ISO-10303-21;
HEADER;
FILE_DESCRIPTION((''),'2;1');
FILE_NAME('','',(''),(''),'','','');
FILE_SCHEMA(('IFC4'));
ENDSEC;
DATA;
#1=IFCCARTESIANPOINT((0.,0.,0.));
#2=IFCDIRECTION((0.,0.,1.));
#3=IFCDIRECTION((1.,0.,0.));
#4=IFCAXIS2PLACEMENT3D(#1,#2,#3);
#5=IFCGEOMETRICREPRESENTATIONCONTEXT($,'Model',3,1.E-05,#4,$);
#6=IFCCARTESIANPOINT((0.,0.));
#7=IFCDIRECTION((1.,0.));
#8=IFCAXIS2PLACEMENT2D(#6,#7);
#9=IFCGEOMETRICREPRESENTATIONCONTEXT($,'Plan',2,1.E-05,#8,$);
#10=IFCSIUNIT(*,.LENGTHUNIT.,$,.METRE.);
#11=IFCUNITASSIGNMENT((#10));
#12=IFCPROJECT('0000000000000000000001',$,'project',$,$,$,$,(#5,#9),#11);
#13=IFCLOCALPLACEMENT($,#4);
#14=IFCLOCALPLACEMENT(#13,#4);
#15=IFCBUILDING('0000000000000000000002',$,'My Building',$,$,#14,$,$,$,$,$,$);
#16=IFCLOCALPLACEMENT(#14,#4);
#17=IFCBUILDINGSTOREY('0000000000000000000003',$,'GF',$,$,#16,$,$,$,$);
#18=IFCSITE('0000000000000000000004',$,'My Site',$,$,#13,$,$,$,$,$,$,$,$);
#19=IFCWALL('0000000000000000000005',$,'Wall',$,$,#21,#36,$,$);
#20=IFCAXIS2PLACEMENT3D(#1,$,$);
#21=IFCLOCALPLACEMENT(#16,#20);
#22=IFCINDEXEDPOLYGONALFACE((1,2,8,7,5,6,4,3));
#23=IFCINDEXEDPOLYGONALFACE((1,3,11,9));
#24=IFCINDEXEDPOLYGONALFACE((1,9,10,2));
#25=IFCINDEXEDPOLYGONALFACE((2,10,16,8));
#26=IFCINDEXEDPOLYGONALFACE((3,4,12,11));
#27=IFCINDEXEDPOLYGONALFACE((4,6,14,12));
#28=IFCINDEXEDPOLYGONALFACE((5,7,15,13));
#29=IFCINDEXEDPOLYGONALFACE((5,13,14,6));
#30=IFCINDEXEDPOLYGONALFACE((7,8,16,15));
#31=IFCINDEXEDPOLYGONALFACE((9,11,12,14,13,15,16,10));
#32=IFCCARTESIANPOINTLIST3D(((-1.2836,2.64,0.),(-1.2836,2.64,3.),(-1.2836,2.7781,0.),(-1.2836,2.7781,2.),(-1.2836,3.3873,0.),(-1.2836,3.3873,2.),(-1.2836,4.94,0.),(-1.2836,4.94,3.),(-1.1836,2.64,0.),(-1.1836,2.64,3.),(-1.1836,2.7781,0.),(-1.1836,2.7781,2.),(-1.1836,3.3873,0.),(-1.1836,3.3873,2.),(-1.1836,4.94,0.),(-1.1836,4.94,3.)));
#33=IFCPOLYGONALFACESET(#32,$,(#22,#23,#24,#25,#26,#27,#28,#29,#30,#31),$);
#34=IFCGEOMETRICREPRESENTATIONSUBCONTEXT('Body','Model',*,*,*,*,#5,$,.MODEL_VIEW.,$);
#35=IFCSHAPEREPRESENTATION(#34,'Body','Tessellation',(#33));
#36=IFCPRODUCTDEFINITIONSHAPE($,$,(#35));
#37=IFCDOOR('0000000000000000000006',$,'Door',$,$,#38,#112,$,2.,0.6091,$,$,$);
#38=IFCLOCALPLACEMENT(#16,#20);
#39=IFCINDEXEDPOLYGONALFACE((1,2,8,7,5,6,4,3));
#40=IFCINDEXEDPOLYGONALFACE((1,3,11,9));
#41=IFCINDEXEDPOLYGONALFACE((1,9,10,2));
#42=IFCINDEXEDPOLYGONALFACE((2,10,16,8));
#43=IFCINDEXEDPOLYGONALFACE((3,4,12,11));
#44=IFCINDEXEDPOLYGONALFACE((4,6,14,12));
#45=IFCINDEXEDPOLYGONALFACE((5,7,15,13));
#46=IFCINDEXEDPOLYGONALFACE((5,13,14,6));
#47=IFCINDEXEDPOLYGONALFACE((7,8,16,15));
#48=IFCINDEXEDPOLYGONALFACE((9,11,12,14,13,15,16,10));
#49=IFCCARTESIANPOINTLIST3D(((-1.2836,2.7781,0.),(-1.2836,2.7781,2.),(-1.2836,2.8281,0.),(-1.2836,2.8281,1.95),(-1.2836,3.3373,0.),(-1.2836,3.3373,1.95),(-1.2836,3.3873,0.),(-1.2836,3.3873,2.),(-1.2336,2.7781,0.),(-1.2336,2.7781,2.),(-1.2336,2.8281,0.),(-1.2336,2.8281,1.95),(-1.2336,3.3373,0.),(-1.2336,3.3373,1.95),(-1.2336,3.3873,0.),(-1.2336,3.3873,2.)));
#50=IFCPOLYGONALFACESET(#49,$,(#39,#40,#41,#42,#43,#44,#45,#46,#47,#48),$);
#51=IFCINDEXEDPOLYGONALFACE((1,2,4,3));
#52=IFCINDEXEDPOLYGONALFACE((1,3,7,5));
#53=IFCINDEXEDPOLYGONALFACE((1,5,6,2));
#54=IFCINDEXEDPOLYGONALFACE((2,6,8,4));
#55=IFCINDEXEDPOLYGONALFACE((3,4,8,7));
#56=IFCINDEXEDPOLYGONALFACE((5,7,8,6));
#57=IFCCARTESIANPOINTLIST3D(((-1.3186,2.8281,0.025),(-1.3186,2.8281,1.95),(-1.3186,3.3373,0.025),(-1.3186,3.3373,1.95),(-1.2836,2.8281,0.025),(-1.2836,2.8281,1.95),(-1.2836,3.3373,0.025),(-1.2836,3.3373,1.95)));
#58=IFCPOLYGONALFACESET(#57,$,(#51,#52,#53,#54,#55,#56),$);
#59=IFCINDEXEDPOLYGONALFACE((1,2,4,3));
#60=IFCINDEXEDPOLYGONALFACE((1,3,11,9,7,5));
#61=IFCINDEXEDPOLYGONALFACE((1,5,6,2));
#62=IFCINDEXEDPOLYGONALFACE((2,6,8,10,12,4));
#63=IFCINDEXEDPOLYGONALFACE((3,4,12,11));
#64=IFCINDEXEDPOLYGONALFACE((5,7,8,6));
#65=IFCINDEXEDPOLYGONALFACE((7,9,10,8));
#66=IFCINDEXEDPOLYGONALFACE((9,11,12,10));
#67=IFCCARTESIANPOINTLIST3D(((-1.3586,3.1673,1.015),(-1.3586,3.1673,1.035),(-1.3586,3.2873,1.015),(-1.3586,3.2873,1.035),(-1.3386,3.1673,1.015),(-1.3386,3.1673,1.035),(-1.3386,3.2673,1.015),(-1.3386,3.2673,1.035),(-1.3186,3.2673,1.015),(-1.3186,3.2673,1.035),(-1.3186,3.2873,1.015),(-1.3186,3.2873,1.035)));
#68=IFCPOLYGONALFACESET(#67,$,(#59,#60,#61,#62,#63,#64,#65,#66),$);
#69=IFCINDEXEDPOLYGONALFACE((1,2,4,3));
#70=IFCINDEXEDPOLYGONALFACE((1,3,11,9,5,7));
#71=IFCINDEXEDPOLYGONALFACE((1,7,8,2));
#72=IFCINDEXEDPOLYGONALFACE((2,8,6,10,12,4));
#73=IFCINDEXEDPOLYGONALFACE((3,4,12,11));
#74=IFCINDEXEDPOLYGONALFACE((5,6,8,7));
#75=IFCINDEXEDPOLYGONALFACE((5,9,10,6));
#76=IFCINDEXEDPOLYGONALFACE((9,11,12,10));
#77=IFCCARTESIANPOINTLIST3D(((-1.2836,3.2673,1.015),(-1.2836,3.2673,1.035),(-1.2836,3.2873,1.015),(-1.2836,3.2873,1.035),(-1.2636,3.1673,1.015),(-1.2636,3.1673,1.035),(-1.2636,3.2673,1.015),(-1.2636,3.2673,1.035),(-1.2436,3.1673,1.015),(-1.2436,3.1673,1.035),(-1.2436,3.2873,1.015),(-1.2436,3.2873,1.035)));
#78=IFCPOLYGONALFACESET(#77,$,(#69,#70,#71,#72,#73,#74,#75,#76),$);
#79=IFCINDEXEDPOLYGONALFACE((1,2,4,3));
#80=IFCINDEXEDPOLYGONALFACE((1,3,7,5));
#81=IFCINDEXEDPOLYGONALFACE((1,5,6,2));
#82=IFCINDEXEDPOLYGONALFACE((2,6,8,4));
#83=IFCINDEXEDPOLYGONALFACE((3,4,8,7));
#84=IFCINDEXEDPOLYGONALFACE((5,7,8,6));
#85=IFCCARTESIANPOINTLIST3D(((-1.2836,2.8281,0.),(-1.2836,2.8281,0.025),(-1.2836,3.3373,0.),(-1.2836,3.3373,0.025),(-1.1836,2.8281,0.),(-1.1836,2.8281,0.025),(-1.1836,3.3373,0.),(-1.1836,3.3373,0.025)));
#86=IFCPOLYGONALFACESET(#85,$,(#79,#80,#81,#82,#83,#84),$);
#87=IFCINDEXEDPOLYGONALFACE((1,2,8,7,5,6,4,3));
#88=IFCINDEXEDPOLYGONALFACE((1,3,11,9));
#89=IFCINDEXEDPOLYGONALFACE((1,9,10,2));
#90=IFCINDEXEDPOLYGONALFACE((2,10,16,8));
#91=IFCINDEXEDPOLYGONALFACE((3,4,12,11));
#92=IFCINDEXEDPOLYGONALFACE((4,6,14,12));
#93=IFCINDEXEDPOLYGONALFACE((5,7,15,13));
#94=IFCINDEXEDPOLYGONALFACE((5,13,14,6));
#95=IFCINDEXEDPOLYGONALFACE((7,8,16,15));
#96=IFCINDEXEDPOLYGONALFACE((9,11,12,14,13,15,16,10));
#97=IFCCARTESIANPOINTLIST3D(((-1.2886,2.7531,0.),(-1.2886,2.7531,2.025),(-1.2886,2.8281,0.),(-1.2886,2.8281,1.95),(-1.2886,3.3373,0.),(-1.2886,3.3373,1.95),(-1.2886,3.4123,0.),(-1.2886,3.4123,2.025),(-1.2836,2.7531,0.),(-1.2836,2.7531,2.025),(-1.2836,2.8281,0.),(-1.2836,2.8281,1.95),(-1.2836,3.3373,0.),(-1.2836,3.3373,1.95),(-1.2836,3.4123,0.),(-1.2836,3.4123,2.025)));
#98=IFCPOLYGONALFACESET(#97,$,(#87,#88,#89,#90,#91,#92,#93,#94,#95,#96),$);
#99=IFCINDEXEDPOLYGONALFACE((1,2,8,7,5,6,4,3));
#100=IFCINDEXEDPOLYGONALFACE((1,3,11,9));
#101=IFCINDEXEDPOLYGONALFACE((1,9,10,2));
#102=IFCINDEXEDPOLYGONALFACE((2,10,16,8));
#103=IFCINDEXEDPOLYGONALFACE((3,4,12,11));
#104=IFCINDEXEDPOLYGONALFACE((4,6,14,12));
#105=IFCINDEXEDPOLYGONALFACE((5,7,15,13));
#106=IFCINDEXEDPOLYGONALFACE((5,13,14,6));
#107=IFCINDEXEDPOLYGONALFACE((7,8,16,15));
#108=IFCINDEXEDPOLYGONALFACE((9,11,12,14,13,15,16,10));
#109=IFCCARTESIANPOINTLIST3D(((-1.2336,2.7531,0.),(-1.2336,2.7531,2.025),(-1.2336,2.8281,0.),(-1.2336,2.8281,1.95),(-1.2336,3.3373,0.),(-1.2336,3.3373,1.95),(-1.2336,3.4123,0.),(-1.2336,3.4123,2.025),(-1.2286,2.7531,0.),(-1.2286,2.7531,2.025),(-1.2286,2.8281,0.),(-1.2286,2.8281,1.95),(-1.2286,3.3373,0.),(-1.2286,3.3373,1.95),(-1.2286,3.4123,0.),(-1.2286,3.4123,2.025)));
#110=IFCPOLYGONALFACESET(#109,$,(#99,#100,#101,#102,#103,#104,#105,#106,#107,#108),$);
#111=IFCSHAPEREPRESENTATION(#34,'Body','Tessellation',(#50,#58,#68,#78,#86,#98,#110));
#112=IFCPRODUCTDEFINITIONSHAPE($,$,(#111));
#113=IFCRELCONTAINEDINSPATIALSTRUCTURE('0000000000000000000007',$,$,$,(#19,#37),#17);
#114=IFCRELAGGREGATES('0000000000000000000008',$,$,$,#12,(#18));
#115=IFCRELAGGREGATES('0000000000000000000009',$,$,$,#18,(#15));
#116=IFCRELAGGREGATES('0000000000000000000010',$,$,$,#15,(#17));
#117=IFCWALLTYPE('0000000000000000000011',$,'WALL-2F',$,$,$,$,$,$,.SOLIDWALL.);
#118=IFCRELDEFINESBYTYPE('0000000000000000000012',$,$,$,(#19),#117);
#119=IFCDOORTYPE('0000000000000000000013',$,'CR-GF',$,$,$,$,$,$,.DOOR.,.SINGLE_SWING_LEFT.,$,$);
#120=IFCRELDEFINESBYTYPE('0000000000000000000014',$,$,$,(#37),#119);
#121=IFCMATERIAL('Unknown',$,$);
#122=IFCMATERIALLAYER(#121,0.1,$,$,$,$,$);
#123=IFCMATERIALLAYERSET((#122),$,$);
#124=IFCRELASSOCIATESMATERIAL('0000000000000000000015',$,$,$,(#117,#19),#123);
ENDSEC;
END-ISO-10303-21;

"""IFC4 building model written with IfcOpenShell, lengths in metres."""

from ifc_helpers import new_model, entity, si_unit, frame, origin_with_axes, origin_2d_with_axis, place, context, subcontext, project, spatial, line, indexed_curve, outline, extrude, shape, source, transform, mapped, material, layer, layer_set, layer_usage, type_object, type_shapes, element, fill, save


model = new_model("IFC4")

# Units and contexts
model_context = context("Model", 3, precision=1e-05, world=origin_with_axes())
plan_context = context("Plan", 2, precision=1e-05, world=origin_2d_with_axis())
body_context_1 = subcontext(model_context, "Body", "Model", "MODEL_VIEW")
body_context_2 = subcontext(plan_context, "Body", "Plan", "PLAN_VIEW")
ifc_project = project(units=[si_unit("LENGTHUNIT", "METRE")], contexts=[model_context, plan_context])

# Site, building, storey
site_placement = place(None, origin_with_axes())
site = spatial("IfcSite", under=ifc_project, at=site_placement, Name="My Site")
building_placement = place(site_placement, origin_with_axes())
building = spatial("IfcBuilding", under=site, at=building_placement, Name="My Building")
storey_placement = place(building_placement, origin_with_axes())
storey = spatial("IfcBuildingStorey", under=building, at=storey_placement, Name="GF")

# Shared definitions
ifc_material = material(Name="Unknown")

# Shared definitions
ifc_layer_1 = layer(ifc_material, 0.1)
ifc_layer_set_1 = layer_set([ifc_layer_1])
wall_type = type_object("IfcWallType", Name="WALL-2F", PredefinedType="SOLIDWALL", material=ifc_layer_set_1)

# Wall, opening, door
ifc_layer_usage_1 = layer_usage(ifc_layer_set_1, "AXIS2", "POSITIVE", 0.0)
wall_1_placement = place(storey_placement, frame((-1.1836, 2.64, 0.0), z_axis=(0.0, 0.0, 1.0), x_axis=(0.0, 1.0, 0.0)))
wall_1 = element("IfcWall", 1, at=wall_1_placement, inside=storey, type_object=wall_type, material=ifc_layer_usage_1, Name="Wall", context=body_context_1, shape_type="SweptSolid", body=[
    extrude(outline(indexed_curve([(0.0, 0.0), (0.0, 0.1), (2.3, 0.1), (2.3, 0.0)], segments=[line(1, 2, 3, 4, 1)])), origin_with_axes(), (0.0, 0.0, 1.0), 3.0),
])
shared_shape_1 = source(origin_with_axes(), body_context_1, "Body", "SweptSolid", [
    extrude(outline(indexed_curve([(0.0, 0.0), (0.6091, 0.0), (0.6091, 2.0), (0.0, 2.0)], segments=[line(1, 2, 3, 4, 1)])), frame((0.0, -0.6, 0.0), z_axis=(0.0, -1.0, 0.0), x_axis=(1.0, 0.0, 0.0)), (0.0, 0.0, -1.0), 1.2),
])
opening_1_placement = place(wall_1_placement, frame((0.7473, 0.1, 0.0), z_axis=(0.0, 0.0, 1.0), x_axis=(-1.0, 0.0, 0.0)))
opening_1 = element("IfcOpeningElement", 2, at=opening_1_placement, cuts=wall_1, PredefinedType="OPENING", context=body_context_1, shape_type="MappedRepresentation", body=[
    mapped(shared_shape_1, transform((0.0, 0.0, 0.0), x_axis=(1.0, 0.0, 0.0), y_axis=(0.0, 1.0, 0.0), z_axis=(0.0, 0.0, 1.0), scale=1.0)),
])
door_type_1 = type_object("IfcDoorType", Name="CR-GF", OperationType="SINGLE_SWING_LEFT", PredefinedType="DOOR")
shared_shape_2 = source(origin_with_axes(), body_context_1, "Body", "SweptSolid", [
    extrude(outline(indexed_curve([(0.0, 0.0), (0.0, 2.0), (0.6091, 2.0), (0.6091, 0.0), (0.5591, 0.0), (0.5591, 1.95), (0.05, 1.95), (0.05, 0.0)], segments=[line(1, 2, 3, 4, 5, 6, 7, 8, 1)])), frame((0.0, 0.0, 0.0), z_axis=(0.0, -1.0, 0.0), x_axis=(1.0, 0.0, 0.0)), (0.0, 0.0, -1.0), 0.05),
    extrude(outline(indexed_curve([(0.0, 0.0), (0.5091, 0.0), (0.5091, 0.035), (0.0, 0.035)], segments=[line(1, 2, 3, 4, 1)])), frame((0.05, -0.035, 0.025), z_axis=(0.0, 0.0, 1.0), x_axis=(1.0, 0.0, 0.0)), (0.0, 0.0, 1.0), 1.925),
    extrude(outline(indexed_curve([(0.0, 0.0), (0.0, -0.04), (0.12, -0.04), (0.12, -0.02), (0.02, -0.02), (0.02, 0.0)], segments=[line(1, 2, 3, 4, 5, 6, 1)])), frame((0.1, -0.035, 1.015), z_axis=(0.0, 0.0, 1.0), x_axis=(1.0, 0.0, 0.0)), (0.0, 0.0, 1.0), 0.02),
    extrude(outline(indexed_curve([(0.0, 0.0), (0.0, 0.04), (0.12, 0.04), (0.12, 0.02), (0.02, 0.02), (0.02, 0.0)], segments=[line(1, 2, 3, 4, 5, 6, 1)])), frame((0.1, 0.0, 1.015), z_axis=(0.0, 0.0, 1.0), x_axis=(1.0, 0.0, 0.0)), (0.0, 0.0, 1.0), 0.02),
    extrude(outline(indexed_curve([(0.0, 0.0), (0.5091, 0.0), (0.5091, 0.1), (0.0, 0.1)], segments=[line(1, 2, 3, 4, 1)])), frame((0.05, 0.0, 0.0), z_axis=(0.0, 0.0, 1.0), x_axis=(1.0, 0.0, 0.0)), (0.0, 0.0, 1.0), 0.025),
    extrude(outline(indexed_curve([(0.0, 0.0), (0.0, 2.025), (0.6591, 2.025), (0.6591, 0.0), (0.5841, 0.0), (0.5841, 1.95), (0.075, 1.95), (0.075, 0.0)], segments=[line(1, 2, 3, 4, 5, 6, 7, 8, 1)])), frame((-0.025, -0.005, 0.0), z_axis=(0.0, -1.0, 0.0), x_axis=(1.0, 0.0, 0.0)), (0.0, 0.0, -1.0), 0.005),
    extrude(outline(indexed_curve([(0.0, 0.0), (0.0, 2.025), (0.6591, 2.025), (0.6591, 0.0), (0.5841, 0.0), (0.5841, 1.95), (0.075, 1.95), (0.075, 0.0)], segments=[line(1, 2, 3, 4, 5, 6, 7, 8, 1)])), frame((-0.025, 0.05, 0.0), z_axis=(0.0, -1.0, 0.0), x_axis=(1.0, 0.0, 0.0)), (0.0, 0.0, -1.0), 0.005),
])
shared_shape_3 = source(origin_with_axes(), body_context_2, "Body", "Curve2D", [
    entity("IfcIndexedPolyCurve", entity("IfcCartesianPointList2D", [[0.0, 0.0], [0.05, 0.0], [0.05, 0.05], [0.0, 0.05]]), [entity("IfcLineIndex", [1, 2, 3, 4, 1])]),
    entity("IfcIndexedPolyCurve", entity("IfcCartesianPointList2D", [[0.6091, 0.0], [0.5591, 0.0], [0.5591, 0.05], [0.6091, 0.05]]), [entity("IfcLineIndex", [1, 2, 3, 4, 1])]),
    entity("IfcIndexedPolyCurve", entity("IfcCartesianPointList2D", [[0.8137, -0.035], [0.3046, -0.035], [0.3046, 0.0], [0.8137, 0.0]]), [entity("IfcLineIndex", [1, 2, 3, 4, 1])]),
])
type_shapes(door_type_1, [shared_shape_2, shared_shape_3])
door_1_placement = place(opening_1_placement, frame((0.0, 0.0, 0.0), z_axis=(0.0, 0.0, 1.0), x_axis=(1.0, 0.0, 0.0)))
door_1 = element("IfcDoor", 3, at=door_1_placement, inside=storey, type_object=door_type_1, Name="Door", OverallHeight=2.0, OverallWidth=0.6091, shapes=[
    shape(body_context_1, "Body", "MappedRepresentation", [mapped(shared_shape_2, transform((0.0, 0.0, 0.0), x_axis=(1.0, 0.0, 0.0), y_axis=(0.0, 1.0, 0.0), z_axis=(0.0, 0.0, 1.0), scale=1.0))]),
    shape(body_context_2, "Body", "MappedRepresentation", [mapped(shared_shape_3, transform((0.0, 0.0, 0.0), x_axis=(1.0, 0.0, 0.0), y_axis=(0.0, 1.0, 0.0), z_axis=(0.0, 0.0, 1.0), scale=1.0))]),
])
fill(opening_1, door_1)

save(model, "model.ifc")
